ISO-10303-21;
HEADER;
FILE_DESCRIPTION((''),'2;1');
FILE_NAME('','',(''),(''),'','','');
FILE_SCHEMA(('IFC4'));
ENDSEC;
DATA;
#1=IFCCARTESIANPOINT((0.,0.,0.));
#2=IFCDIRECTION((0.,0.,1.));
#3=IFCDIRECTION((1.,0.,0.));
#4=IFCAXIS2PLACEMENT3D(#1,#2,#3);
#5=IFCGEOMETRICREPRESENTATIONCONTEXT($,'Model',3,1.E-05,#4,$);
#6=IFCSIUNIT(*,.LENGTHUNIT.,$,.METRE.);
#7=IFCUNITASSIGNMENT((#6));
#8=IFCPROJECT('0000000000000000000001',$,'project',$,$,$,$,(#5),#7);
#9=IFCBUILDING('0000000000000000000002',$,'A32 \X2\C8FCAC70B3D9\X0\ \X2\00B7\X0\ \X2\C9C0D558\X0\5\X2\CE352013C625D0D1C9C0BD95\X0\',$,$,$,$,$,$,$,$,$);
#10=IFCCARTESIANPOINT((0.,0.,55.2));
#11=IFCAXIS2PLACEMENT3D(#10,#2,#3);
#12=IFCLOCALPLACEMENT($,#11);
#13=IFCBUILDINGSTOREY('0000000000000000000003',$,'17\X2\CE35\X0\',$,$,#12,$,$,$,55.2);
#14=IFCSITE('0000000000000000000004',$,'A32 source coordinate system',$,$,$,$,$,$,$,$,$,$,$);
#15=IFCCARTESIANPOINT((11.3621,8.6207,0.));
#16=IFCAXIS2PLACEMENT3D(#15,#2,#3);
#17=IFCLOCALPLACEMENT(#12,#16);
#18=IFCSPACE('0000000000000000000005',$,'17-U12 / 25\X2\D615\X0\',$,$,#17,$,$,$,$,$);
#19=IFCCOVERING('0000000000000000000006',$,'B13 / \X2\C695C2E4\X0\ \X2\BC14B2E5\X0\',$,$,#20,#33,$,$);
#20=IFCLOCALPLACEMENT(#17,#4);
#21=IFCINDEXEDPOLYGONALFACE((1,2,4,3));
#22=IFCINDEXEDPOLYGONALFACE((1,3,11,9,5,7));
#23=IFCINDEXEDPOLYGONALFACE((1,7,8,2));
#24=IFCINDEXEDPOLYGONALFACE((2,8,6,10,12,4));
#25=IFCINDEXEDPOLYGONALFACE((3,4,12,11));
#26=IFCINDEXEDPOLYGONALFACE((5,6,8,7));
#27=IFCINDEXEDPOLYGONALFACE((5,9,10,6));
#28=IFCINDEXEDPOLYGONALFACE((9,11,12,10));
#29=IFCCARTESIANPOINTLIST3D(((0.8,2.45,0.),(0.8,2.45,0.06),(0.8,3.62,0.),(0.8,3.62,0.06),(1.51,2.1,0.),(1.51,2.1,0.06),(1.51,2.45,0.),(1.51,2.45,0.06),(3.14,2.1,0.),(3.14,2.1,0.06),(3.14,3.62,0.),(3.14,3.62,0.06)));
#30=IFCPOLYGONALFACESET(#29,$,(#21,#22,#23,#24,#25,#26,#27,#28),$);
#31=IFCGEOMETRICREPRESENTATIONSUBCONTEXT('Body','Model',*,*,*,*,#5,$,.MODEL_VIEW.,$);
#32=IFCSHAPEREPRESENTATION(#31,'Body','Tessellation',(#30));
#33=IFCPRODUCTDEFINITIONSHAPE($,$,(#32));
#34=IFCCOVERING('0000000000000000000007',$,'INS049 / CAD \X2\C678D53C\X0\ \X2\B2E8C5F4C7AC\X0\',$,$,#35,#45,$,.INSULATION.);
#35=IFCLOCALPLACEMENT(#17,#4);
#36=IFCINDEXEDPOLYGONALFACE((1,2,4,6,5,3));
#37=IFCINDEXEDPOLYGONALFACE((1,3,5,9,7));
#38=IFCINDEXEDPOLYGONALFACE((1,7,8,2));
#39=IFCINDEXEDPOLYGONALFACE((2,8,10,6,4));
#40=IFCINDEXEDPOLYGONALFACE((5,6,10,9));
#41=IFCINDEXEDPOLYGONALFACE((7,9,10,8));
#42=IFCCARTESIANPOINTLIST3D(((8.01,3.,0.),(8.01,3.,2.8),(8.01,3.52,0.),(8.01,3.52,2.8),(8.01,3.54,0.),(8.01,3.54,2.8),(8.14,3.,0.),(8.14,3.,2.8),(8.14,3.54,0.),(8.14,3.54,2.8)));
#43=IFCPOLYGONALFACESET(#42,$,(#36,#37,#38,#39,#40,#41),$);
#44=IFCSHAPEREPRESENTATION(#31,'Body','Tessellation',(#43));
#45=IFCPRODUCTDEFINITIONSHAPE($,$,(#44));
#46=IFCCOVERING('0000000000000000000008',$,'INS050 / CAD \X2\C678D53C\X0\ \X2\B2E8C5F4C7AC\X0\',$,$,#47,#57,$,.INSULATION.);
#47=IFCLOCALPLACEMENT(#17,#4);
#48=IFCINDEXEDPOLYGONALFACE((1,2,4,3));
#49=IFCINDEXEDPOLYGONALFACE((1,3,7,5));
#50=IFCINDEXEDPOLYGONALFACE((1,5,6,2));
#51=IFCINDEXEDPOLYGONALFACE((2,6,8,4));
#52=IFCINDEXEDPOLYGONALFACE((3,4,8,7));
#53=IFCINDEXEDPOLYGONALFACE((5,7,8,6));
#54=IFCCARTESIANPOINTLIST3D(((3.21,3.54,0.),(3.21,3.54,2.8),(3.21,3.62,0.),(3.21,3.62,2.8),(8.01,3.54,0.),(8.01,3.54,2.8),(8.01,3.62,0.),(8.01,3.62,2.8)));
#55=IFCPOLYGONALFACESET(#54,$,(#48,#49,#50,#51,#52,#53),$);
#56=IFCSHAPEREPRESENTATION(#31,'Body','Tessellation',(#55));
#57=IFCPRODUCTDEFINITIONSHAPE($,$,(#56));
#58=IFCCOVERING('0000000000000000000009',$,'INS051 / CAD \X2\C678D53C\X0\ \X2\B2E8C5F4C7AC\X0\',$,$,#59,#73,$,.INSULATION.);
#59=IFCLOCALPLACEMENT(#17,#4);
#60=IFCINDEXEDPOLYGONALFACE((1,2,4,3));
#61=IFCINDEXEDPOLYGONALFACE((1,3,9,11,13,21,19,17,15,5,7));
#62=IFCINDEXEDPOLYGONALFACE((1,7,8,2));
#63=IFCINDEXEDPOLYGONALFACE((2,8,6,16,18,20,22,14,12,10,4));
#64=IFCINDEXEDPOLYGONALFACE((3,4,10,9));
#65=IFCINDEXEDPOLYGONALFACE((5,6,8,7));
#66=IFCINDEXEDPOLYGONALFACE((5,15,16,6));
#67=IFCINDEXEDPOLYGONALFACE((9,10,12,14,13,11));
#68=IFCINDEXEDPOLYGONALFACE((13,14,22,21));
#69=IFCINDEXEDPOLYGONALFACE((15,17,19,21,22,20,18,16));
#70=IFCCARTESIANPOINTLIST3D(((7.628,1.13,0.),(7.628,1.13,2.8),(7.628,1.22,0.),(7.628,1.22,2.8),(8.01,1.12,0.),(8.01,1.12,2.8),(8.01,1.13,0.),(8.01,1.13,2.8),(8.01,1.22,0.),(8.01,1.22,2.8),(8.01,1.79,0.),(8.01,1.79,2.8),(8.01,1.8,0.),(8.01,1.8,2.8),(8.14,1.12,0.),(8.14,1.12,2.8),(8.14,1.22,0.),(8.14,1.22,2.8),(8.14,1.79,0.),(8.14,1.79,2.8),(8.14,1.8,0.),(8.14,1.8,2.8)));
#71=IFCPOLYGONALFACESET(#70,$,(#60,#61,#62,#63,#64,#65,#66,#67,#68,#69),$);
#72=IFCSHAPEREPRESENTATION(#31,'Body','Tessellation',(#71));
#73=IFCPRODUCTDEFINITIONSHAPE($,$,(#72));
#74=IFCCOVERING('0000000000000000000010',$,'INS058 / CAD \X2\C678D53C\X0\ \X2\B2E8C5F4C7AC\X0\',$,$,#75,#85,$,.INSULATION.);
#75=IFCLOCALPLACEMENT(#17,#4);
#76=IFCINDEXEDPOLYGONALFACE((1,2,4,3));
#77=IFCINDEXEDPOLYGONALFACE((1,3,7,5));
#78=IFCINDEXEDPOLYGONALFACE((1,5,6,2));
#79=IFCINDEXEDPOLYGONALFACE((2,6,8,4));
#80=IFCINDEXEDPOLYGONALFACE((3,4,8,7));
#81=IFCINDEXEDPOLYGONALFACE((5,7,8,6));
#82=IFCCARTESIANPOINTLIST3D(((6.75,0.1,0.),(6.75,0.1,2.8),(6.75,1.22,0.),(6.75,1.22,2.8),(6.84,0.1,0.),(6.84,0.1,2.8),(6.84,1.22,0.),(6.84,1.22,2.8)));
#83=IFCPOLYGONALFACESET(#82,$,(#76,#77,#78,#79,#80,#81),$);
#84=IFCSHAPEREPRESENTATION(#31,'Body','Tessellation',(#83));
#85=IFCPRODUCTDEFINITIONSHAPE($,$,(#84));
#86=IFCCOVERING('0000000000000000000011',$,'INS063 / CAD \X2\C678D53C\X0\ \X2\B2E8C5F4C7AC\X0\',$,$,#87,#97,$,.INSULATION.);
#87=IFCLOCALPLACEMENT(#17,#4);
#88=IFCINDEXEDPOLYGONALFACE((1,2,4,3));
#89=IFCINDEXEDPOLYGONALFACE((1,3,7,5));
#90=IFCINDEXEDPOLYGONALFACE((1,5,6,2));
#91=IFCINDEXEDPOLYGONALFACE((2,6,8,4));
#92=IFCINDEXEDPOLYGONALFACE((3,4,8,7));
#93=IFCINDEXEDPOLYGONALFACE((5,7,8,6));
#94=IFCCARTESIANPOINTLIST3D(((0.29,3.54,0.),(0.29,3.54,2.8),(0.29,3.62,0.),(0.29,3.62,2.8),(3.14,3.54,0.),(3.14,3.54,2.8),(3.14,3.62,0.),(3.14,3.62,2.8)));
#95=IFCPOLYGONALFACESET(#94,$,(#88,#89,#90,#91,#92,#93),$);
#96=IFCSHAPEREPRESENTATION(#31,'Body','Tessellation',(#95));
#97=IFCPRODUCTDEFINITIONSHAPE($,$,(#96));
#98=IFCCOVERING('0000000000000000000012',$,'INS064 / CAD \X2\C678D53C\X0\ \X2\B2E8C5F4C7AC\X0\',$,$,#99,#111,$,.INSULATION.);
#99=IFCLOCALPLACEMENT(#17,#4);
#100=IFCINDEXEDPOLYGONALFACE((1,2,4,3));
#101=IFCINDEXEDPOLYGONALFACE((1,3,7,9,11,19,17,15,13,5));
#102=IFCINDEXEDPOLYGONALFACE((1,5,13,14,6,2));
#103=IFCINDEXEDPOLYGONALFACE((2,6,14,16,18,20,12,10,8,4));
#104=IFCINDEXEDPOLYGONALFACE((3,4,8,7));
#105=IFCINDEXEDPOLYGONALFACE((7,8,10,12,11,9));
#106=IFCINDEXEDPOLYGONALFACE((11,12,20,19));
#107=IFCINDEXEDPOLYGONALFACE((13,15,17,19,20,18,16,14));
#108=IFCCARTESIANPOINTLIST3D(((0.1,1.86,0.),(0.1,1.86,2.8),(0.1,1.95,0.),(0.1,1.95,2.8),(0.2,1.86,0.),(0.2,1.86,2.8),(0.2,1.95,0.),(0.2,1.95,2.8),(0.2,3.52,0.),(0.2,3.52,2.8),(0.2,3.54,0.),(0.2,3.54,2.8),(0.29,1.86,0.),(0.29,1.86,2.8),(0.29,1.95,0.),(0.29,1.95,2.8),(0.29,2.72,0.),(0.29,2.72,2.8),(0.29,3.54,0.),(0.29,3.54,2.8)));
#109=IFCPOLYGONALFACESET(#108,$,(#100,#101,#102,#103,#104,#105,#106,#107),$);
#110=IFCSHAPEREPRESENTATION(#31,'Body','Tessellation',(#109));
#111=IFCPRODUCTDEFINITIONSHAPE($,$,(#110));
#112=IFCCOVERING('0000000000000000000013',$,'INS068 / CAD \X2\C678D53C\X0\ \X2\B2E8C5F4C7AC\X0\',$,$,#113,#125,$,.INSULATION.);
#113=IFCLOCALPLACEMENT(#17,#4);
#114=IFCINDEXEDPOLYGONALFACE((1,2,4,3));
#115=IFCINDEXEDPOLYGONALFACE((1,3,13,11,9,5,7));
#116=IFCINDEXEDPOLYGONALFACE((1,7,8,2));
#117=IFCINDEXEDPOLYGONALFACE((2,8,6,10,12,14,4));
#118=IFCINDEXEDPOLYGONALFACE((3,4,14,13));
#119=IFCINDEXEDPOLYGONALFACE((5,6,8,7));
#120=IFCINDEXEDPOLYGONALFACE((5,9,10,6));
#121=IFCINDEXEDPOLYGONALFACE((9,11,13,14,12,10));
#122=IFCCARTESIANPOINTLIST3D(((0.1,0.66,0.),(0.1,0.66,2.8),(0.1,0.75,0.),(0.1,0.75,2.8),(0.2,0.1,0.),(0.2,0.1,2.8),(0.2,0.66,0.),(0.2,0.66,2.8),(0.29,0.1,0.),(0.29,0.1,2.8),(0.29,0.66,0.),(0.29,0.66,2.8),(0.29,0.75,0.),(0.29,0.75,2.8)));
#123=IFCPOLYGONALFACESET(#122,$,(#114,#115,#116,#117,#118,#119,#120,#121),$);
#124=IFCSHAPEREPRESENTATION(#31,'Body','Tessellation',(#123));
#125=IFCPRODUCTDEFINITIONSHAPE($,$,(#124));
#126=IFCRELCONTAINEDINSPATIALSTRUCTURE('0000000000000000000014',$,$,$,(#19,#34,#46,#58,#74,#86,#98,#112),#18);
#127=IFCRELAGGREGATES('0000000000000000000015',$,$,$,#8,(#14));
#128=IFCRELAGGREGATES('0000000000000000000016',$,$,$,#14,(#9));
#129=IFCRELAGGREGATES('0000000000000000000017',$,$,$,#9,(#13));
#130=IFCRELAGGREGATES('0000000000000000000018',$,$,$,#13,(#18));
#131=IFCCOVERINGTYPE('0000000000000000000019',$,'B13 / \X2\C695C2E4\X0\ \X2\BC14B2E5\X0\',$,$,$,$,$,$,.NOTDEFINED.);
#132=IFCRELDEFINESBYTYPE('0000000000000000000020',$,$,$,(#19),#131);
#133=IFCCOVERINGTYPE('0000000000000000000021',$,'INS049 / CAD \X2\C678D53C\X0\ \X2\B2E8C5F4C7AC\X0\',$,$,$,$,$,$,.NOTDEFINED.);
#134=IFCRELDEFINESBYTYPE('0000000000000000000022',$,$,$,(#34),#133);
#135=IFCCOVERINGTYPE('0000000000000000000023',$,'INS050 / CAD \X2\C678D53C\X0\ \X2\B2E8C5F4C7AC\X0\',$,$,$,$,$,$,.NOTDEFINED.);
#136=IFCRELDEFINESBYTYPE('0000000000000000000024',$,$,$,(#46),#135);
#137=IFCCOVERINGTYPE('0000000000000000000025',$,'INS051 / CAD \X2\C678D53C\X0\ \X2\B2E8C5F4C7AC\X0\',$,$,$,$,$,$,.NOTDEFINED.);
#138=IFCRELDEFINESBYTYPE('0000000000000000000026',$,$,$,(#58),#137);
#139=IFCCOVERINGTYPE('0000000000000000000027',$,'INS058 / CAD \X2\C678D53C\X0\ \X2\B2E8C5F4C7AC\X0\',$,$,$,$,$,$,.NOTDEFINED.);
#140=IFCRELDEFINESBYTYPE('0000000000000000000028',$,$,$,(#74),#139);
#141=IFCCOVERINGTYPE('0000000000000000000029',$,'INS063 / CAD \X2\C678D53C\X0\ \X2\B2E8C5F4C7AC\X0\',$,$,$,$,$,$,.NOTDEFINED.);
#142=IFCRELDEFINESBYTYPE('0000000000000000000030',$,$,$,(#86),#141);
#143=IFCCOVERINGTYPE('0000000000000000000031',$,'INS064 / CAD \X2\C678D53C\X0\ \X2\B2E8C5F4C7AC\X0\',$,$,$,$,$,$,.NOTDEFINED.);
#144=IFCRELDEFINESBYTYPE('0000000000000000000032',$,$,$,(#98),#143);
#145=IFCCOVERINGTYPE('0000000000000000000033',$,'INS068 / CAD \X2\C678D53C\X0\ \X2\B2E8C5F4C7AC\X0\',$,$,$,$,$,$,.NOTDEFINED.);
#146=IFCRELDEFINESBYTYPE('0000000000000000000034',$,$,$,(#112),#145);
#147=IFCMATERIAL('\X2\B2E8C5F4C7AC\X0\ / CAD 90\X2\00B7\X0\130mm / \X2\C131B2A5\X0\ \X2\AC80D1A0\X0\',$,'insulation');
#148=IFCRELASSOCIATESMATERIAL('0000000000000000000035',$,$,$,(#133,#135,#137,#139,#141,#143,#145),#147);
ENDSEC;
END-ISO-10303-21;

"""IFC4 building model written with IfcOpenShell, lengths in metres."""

from ifc_helpers import new_model, si_unit, frame, origin, origin_with_axes, place, context, subcontext, project, spatial, polyline, outline, extrude, source, transform, mapped, material, type_object, type_shapes, element, save


model = new_model("IFC4")

# Units and contexts
model_context = context("Model", 3, precision=1e-05, world=origin_with_axes())
body_context = subcontext(model_context, "Body", "Model", "MODEL_VIEW")
ifc_project = project(units=[si_unit("LENGTHUNIT", "METRE")], contexts=[model_context])

# Site, building, storey
storey_placement = place(None, frame((0.0, 0.0, 55.2), z_axis=(0.0, 0.0, 1.0), x_axis=(1.0, 0.0, 0.0)))
space_1_placement = place(storey_placement, frame((11.3621, 8.6207, 0.0), z_axis=(0.0, 0.0, 1.0), x_axis=(1.0, 0.0, 0.0)))
site = spatial("IfcSite", under=ifc_project, Name="A32 source coordinate system")
building = spatial("IfcBuilding", under=site, Name="A32 주거동 · 지하5층–옥탑지붕")
storey = spatial("IfcBuildingStorey", under=building, at=storey_placement, Name="17층", Elevation=55.2)

# Shared definitions
space_1 = spatial("IfcSpace", under=storey, at=space_1_placement, Name="17-U12 / 25형")

# Coverings
covering_type_1 = type_object("IfcCoveringType", Name="B13 / 욕실 바닥", PredefinedType="NOTDEFINED")
shared_shape_1 = source(origin(), body_context, "Body", "SweptSolid", [
    extrude(outline(polyline([(3.14, 2.1), (1.51, 2.1), (1.51, 2.45), (0.8, 2.45), (0.8, 3.62), (3.14, 3.62), (3.14, 2.1)])), origin(), (0.0, 0.0, 1.0), 0.06),
])
type_shapes(covering_type_1, [shared_shape_1])
covering_1_placement = place(space_1_placement, origin_with_axes())
element("IfcCovering", 1, at=covering_1_placement, inside=space_1, type_object=covering_type_1, Name="B13 / 욕실 바닥", context=body_context, shape_type="MappedRepresentation", body=[
    mapped(shared_shape_1, transform((0.0, 0.0, 0.0), scale=1.0)),
])
ifc_material = material(Name="단열재 / CAD 90·130mm / 성능 검토", Category="insulation")
covering_type_2 = type_object("IfcCoveringType", Name="INS049 / CAD 외피 단열재", PredefinedType="NOTDEFINED", material=ifc_material)
shared_shape_2 = source(origin(), body_context, "Body", "SweptSolid", [
    extrude(outline(polyline([(8.01, 3.54), (8.14, 3.54), (8.14, 3.0), (8.01, 3.0), (8.01, 3.52), (8.01, 3.54)])), origin(), (0.0, 0.0, 1.0), 2.8),
])
type_shapes(covering_type_2, [shared_shape_2])
covering_2_placement = place(space_1_placement, origin_with_axes())
element("IfcCovering", 2, at=covering_2_placement, inside=space_1, type_object=covering_type_2, Name="INS049 / CAD 외피 단열재", PredefinedType="INSULATION", context=body_context, shape_type="MappedRepresentation", body=[
    mapped(shared_shape_2, transform((0.0, 0.0, 0.0), scale=1.0)),
])
covering_type_3 = type_object("IfcCoveringType", Name="INS050 / CAD 외피 단열재", PredefinedType="NOTDEFINED", material=ifc_material)
shared_shape_3 = source(origin(), body_context, "Body", "SweptSolid", [
    extrude(outline(polyline([(8.01, 3.54), (3.21, 3.54), (3.21, 3.62), (8.01, 3.62), (8.01, 3.54)])), origin(), (0.0, 0.0, 1.0), 2.8),
])
type_shapes(covering_type_3, [shared_shape_3])
covering_3_placement = place(space_1_placement, origin_with_axes())
element("IfcCovering", 3, at=covering_3_placement, inside=space_1, type_object=covering_type_3, Name="INS050 / CAD 외피 단열재", PredefinedType="INSULATION", context=body_context, shape_type="MappedRepresentation", body=[
    mapped(shared_shape_3, transform((0.0, 0.0, 0.0), scale=1.0)),
])
covering_type_4 = type_object("IfcCoveringType", Name="INS051 / CAD 외피 단열재", PredefinedType="NOTDEFINED", material=ifc_material)
shared_shape_4 = source(origin(), body_context, "Body", "SweptSolid", [
    extrude(outline(polyline([(8.14, 1.12), (8.01, 1.12), (8.01, 1.13), (7.628, 1.13), (7.628, 1.22), (8.01, 1.22), (8.01, 1.79), (8.01, 1.8), (8.14, 1.8), (8.14, 1.79), (8.14, 1.22), (8.14, 1.12)])), origin(), (0.0, 0.0, 1.0), 2.8),
])
type_shapes(covering_type_4, [shared_shape_4])
covering_4_placement = place(space_1_placement, origin_with_axes())
element("IfcCovering", 4, at=covering_4_placement, inside=space_1, type_object=covering_type_4, Name="INS051 / CAD 외피 단열재", PredefinedType="INSULATION", context=body_context, shape_type="MappedRepresentation", body=[
    mapped(shared_shape_4, transform((0.0, 0.0, 0.0), scale=1.0)),
])
covering_type_5 = type_object("IfcCoveringType", Name="INS058 / CAD 외피 단열재", PredefinedType="NOTDEFINED", material=ifc_material)
shared_shape_5 = source(origin(), body_context, "Body", "SweptSolid", [
    extrude(outline(polyline([(6.75, 0.1), (6.75, 1.22), (6.84, 1.22), (6.84, 0.1), (6.75, 0.1)])), origin(), (0.0, 0.0, 1.0), 2.8),
])
type_shapes(covering_type_5, [shared_shape_5])
covering_5_placement = place(space_1_placement, origin_with_axes())
element("IfcCovering", 5, at=covering_5_placement, inside=space_1, type_object=covering_type_5, Name="INS058 / CAD 외피 단열재", PredefinedType="INSULATION", context=body_context, shape_type="MappedRepresentation", body=[
    mapped(shared_shape_5, transform((0.0, 0.0, 0.0), scale=1.0)),
])
covering_type_6 = type_object("IfcCoveringType", Name="INS063 / CAD 외피 단열재", PredefinedType="NOTDEFINED", material=ifc_material)
shared_shape_6 = source(origin(), body_context, "Body", "SweptSolid", [
    extrude(outline(polyline([(0.29, 3.54), (0.29, 3.62), (3.14, 3.62), (3.14, 3.54), (0.29, 3.54)])), origin(), (0.0, 0.0, 1.0), 2.8),
])
type_shapes(covering_type_6, [shared_shape_6])
covering_6_placement = place(space_1_placement, origin_with_axes())
element("IfcCovering", 6, at=covering_6_placement, inside=space_1, type_object=covering_type_6, Name="INS063 / CAD 외피 단열재", PredefinedType="INSULATION", context=body_context, shape_type="MappedRepresentation", body=[
    mapped(shared_shape_6, transform((0.0, 0.0, 0.0), scale=1.0)),
])
covering_type_7 = type_object("IfcCoveringType", Name="INS064 / CAD 외피 단열재", PredefinedType="NOTDEFINED", material=ifc_material)
shared_shape_7 = source(origin(), body_context, "Body", "SweptSolid", [
    extrude(outline(polyline([(0.1, 1.86), (0.1, 1.95), (0.2, 1.95), (0.2, 3.52), (0.2, 3.54), (0.29, 3.54), (0.29, 2.72), (0.29, 1.95), (0.29, 1.86), (0.2, 1.86), (0.1, 1.86)])), origin(), (0.0, 0.0, 1.0), 2.8),
])
type_shapes(covering_type_7, [shared_shape_7])
covering_7_placement = place(space_1_placement, origin_with_axes())
element("IfcCovering", 7, at=covering_7_placement, inside=space_1, type_object=covering_type_7, Name="INS064 / CAD 외피 단열재", PredefinedType="INSULATION", context=body_context, shape_type="MappedRepresentation", body=[
    mapped(shared_shape_7, transform((0.0, 0.0, 0.0), scale=1.0)),
])
covering_type_8 = type_object("IfcCoveringType", Name="INS068 / CAD 외피 단열재", PredefinedType="NOTDEFINED", material=ifc_material)
shared_shape_8 = source(origin(), body_context, "Body", "SweptSolid", [
    extrude(outline(polyline([(0.2, 0.1), (0.2, 0.66), (0.1, 0.66), (0.1, 0.75), (0.29, 0.75), (0.29, 0.66), (0.29, 0.1), (0.2, 0.1)])), origin(), (0.0, 0.0, 1.0), 2.8),
])
type_shapes(covering_type_8, [shared_shape_8])
covering_8_placement = place(space_1_placement, origin_with_axes())
element("IfcCovering", 8, at=covering_8_placement, inside=space_1, type_object=covering_type_8, Name="INS068 / CAD 외피 단열재", PredefinedType="INSULATION", context=body_context, shape_type="MappedRepresentation", body=[
    mapped(shared_shape_8, transform((0.0, 0.0, 0.0), scale=1.0)),
])

save(model, "model.ifc")
